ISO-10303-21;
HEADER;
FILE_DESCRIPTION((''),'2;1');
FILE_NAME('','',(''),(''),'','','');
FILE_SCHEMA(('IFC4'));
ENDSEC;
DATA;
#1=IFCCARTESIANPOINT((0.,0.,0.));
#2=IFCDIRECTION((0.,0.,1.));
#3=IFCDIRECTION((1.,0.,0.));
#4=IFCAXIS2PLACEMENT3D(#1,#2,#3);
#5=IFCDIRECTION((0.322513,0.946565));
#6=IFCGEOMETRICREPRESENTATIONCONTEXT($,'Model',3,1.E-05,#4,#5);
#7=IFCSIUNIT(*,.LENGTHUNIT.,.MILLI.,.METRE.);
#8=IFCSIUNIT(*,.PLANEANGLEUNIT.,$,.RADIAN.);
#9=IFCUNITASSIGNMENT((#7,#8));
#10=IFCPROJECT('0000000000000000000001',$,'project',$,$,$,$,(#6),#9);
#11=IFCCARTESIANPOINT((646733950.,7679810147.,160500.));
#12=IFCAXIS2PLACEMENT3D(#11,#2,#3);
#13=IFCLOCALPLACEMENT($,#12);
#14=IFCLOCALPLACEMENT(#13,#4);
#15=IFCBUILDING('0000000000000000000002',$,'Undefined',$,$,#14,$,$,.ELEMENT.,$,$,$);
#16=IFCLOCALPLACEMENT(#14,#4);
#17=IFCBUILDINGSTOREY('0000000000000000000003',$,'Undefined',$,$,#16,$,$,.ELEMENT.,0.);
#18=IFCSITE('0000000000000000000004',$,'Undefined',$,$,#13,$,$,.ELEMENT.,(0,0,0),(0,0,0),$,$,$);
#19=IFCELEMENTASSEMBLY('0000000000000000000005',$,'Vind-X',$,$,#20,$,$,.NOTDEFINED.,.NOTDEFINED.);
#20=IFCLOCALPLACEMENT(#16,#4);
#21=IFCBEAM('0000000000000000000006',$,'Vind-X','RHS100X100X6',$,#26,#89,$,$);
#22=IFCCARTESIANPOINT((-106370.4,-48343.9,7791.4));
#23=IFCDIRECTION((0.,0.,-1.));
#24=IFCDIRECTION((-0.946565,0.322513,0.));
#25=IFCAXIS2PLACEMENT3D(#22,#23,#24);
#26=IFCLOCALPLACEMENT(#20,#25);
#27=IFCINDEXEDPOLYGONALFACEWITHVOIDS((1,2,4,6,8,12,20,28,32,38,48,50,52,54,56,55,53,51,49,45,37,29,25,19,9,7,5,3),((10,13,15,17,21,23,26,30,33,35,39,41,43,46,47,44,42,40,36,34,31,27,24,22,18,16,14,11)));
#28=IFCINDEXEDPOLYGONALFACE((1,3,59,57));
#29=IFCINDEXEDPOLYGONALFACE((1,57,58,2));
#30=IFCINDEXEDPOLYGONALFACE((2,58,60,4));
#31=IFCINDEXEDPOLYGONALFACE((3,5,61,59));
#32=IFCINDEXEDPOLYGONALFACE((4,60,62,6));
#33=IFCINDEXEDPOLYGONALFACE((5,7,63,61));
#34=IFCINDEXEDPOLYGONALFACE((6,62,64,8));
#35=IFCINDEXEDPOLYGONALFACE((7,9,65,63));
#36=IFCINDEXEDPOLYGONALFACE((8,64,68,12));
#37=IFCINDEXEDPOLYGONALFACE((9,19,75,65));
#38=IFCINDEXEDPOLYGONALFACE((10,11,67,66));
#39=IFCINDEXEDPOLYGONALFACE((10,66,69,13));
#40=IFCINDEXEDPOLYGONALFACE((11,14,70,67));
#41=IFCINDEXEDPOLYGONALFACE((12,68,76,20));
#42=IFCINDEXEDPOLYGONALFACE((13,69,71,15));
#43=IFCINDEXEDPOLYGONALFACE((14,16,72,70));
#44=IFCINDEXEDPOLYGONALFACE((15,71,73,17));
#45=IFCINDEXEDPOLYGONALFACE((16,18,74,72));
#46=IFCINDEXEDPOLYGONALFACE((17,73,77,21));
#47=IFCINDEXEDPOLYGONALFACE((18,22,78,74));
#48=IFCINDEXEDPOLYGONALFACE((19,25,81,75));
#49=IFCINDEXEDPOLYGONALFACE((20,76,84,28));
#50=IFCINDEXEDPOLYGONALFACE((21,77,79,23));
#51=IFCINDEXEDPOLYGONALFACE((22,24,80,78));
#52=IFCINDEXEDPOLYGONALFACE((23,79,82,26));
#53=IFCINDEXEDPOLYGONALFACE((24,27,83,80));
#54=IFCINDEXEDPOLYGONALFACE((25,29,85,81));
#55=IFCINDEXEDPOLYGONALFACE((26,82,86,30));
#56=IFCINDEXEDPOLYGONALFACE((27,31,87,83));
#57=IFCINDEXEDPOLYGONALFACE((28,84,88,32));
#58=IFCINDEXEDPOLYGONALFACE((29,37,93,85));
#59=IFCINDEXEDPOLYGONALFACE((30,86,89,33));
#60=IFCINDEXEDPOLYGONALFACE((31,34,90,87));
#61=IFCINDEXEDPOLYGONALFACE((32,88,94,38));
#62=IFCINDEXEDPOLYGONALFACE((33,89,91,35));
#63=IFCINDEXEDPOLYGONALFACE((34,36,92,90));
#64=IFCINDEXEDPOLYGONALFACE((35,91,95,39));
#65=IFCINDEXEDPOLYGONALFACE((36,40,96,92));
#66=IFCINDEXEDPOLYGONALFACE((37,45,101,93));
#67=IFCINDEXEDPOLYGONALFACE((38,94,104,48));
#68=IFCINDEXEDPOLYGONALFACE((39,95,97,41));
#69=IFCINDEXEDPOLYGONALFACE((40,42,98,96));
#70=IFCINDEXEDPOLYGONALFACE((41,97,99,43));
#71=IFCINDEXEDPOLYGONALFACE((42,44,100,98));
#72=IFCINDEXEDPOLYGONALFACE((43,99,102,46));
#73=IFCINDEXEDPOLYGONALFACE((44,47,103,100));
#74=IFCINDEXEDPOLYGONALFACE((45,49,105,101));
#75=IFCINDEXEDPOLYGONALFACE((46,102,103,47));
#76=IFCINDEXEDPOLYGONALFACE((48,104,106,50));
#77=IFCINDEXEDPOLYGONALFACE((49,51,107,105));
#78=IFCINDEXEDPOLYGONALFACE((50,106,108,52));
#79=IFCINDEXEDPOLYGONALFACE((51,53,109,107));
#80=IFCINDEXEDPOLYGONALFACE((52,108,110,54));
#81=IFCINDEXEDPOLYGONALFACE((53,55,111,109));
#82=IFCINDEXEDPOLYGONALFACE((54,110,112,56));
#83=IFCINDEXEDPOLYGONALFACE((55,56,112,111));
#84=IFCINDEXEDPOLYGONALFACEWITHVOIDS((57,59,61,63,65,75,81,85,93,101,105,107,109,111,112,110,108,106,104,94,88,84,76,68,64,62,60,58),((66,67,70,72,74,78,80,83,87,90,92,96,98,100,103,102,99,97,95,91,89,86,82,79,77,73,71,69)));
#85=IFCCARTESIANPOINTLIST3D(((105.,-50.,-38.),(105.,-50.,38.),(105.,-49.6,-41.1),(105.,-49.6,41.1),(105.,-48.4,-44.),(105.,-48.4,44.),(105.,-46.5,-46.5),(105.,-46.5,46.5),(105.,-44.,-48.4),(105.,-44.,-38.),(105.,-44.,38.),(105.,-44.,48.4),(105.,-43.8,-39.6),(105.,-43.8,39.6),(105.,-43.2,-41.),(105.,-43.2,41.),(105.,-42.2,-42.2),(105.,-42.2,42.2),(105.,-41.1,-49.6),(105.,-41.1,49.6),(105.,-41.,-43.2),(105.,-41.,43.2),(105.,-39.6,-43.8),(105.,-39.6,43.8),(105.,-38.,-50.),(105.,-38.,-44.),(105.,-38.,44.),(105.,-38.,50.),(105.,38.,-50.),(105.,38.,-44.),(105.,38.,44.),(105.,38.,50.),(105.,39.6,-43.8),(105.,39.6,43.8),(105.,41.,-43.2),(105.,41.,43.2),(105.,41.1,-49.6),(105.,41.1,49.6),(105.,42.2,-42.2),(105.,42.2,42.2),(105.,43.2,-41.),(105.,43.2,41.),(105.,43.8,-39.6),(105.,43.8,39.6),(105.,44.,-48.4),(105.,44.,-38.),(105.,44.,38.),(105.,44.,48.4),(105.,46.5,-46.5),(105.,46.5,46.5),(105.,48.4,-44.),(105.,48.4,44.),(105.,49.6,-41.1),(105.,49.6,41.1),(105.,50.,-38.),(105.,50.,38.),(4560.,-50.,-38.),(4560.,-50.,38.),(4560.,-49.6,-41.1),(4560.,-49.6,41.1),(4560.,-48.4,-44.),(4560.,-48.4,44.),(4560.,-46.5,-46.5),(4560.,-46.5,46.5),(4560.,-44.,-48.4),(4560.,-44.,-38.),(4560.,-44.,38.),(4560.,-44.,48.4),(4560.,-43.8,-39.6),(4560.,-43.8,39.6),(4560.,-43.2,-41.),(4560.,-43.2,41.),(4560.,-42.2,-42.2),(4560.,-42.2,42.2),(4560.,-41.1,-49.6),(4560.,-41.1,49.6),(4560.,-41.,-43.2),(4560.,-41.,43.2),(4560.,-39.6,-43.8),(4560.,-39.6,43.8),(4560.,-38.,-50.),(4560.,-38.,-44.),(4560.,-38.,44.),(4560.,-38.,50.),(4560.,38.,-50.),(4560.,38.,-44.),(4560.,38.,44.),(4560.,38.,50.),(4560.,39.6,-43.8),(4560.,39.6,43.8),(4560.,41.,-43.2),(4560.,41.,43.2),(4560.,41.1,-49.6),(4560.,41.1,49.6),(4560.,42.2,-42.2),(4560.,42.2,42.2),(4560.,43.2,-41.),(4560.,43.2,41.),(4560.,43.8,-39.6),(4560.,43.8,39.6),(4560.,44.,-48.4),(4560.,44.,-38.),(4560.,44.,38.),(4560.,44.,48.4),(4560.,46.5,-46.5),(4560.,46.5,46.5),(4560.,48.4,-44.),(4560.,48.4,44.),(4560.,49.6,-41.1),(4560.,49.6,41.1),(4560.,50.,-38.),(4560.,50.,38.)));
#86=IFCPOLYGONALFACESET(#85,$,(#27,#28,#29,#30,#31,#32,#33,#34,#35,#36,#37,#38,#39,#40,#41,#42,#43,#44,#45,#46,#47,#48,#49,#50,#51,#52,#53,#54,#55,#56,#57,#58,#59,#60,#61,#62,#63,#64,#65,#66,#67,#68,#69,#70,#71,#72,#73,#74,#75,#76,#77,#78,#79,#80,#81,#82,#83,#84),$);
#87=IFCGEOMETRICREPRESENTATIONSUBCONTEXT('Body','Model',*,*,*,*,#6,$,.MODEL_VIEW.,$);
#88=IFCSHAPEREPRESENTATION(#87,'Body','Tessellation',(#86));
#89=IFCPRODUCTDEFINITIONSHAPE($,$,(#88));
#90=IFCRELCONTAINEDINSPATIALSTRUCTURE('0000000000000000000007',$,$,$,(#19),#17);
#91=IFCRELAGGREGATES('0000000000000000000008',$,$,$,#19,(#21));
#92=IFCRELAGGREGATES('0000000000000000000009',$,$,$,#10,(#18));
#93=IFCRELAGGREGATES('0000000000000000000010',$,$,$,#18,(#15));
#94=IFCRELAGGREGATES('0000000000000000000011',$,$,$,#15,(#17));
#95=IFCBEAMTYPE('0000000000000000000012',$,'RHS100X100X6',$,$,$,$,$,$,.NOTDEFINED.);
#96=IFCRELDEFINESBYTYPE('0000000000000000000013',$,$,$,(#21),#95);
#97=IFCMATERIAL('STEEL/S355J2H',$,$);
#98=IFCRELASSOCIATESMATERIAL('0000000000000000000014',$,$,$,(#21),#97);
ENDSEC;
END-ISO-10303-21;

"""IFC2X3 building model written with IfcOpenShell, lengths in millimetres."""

from ifc_helpers import new_model, si_unit, direction, frame, origin_with_axes, origin_2d_with_axis, place, context, subcontext, project, spatial, hollow_rectangle, extrude, clip, halfspace, material, type_object, element, aggregate, save


model = new_model("IFC2X3")

# Units and contexts
model_context = context("Model", 3, precision=1e-05, world=origin_with_axes(), true_north=direction((0.322513, 0.946565)))
body_context = subcontext(model_context, "Body", "Model", "MODEL_VIEW")
ifc_project = project(units=[si_unit("LENGTHUNIT", "METRE", prefix="MILLI"), si_unit("PLANEANGLEUNIT", "RADIAN")], contexts=[model_context])

# Site, building, storey
site_placement = place(None, frame((646733950.0, 7679810147.0, 160500.0), z_axis=(0.0, 0.0, 1.0), x_axis=(1.0, 0.0, 0.0)))
site = spatial("IfcSite", under=ifc_project, at=site_placement, Name="Undefined", CompositionType="ELEMENT", RefLatitude=(0, 0, 0), RefLongitude=(0, 0, 0))
building_placement = place(site_placement, origin_with_axes())
building = spatial("IfcBuilding", under=site, at=building_placement, Name="Undefined", CompositionType="ELEMENT")
storey_placement = place(building_placement, origin_with_axes())
storey = spatial("IfcBuildingStorey", under=building, at=storey_placement, Name="Undefined", CompositionType="ELEMENT", Elevation=0.0)

# Element assembly, beam
assembly_1_placement = place(storey_placement, origin_with_axes())
assembly_1 = element("IfcElementAssembly", 1, at=assembly_1_placement, inside=storey, Name="Vind-X", AssemblyPlace="NOTDEFINED", PredefinedType="NOTDEFINED")
ifc_material_1 = material(Name="STEEL/S355J2H")
beam_type_1 = type_object("IfcBeamType", Name="RHS100X100X6", PredefinedType="NOTDEFINED")
beam_1_placement = place(assembly_1_placement, frame((-106370.4, -48343.9, 7791.4), z_axis=(0.0, 0.0, -1.0), x_axis=(-0.946565, 0.322513, 0.0)))
beam_1 = element("IfcBeam", 2, at=beam_1_placement, type_object=beam_type_1, material=ifc_material_1, Name="Vind-X", Description="RHS100X100X6", context=body_context, shape_type="Clipping", body=[
    clip(clip(extrude(hollow_rectangle(XDim=100.0, YDim=100.0, WallThickness=6.0, InnerFilletRadius=6.0, OuterFilletRadius=12.0, at=origin_2d_with_axis()), frame((4675.0, 0.0, 0.0), z_axis=(-1.0, 0.0, 0.0), x_axis=(0.0, -1.0, 0.0)), (0.0, 0.0, 1.0), 4675.0), halfspace(frame((4560.0, 0.0, 0.0), z_axis=(-1.0, 0.0, 0.0), x_axis=(0.0, 1.0, 0.0)), True)), halfspace(frame((105.0, 0.0, 0.0), z_axis=(1.0, 0.0, 0.0), x_axis=(0.0, -1.0, 0.0)), True)),
])

aggregate(assembly_1, [beam_1])

save(model, "model.ifc")
